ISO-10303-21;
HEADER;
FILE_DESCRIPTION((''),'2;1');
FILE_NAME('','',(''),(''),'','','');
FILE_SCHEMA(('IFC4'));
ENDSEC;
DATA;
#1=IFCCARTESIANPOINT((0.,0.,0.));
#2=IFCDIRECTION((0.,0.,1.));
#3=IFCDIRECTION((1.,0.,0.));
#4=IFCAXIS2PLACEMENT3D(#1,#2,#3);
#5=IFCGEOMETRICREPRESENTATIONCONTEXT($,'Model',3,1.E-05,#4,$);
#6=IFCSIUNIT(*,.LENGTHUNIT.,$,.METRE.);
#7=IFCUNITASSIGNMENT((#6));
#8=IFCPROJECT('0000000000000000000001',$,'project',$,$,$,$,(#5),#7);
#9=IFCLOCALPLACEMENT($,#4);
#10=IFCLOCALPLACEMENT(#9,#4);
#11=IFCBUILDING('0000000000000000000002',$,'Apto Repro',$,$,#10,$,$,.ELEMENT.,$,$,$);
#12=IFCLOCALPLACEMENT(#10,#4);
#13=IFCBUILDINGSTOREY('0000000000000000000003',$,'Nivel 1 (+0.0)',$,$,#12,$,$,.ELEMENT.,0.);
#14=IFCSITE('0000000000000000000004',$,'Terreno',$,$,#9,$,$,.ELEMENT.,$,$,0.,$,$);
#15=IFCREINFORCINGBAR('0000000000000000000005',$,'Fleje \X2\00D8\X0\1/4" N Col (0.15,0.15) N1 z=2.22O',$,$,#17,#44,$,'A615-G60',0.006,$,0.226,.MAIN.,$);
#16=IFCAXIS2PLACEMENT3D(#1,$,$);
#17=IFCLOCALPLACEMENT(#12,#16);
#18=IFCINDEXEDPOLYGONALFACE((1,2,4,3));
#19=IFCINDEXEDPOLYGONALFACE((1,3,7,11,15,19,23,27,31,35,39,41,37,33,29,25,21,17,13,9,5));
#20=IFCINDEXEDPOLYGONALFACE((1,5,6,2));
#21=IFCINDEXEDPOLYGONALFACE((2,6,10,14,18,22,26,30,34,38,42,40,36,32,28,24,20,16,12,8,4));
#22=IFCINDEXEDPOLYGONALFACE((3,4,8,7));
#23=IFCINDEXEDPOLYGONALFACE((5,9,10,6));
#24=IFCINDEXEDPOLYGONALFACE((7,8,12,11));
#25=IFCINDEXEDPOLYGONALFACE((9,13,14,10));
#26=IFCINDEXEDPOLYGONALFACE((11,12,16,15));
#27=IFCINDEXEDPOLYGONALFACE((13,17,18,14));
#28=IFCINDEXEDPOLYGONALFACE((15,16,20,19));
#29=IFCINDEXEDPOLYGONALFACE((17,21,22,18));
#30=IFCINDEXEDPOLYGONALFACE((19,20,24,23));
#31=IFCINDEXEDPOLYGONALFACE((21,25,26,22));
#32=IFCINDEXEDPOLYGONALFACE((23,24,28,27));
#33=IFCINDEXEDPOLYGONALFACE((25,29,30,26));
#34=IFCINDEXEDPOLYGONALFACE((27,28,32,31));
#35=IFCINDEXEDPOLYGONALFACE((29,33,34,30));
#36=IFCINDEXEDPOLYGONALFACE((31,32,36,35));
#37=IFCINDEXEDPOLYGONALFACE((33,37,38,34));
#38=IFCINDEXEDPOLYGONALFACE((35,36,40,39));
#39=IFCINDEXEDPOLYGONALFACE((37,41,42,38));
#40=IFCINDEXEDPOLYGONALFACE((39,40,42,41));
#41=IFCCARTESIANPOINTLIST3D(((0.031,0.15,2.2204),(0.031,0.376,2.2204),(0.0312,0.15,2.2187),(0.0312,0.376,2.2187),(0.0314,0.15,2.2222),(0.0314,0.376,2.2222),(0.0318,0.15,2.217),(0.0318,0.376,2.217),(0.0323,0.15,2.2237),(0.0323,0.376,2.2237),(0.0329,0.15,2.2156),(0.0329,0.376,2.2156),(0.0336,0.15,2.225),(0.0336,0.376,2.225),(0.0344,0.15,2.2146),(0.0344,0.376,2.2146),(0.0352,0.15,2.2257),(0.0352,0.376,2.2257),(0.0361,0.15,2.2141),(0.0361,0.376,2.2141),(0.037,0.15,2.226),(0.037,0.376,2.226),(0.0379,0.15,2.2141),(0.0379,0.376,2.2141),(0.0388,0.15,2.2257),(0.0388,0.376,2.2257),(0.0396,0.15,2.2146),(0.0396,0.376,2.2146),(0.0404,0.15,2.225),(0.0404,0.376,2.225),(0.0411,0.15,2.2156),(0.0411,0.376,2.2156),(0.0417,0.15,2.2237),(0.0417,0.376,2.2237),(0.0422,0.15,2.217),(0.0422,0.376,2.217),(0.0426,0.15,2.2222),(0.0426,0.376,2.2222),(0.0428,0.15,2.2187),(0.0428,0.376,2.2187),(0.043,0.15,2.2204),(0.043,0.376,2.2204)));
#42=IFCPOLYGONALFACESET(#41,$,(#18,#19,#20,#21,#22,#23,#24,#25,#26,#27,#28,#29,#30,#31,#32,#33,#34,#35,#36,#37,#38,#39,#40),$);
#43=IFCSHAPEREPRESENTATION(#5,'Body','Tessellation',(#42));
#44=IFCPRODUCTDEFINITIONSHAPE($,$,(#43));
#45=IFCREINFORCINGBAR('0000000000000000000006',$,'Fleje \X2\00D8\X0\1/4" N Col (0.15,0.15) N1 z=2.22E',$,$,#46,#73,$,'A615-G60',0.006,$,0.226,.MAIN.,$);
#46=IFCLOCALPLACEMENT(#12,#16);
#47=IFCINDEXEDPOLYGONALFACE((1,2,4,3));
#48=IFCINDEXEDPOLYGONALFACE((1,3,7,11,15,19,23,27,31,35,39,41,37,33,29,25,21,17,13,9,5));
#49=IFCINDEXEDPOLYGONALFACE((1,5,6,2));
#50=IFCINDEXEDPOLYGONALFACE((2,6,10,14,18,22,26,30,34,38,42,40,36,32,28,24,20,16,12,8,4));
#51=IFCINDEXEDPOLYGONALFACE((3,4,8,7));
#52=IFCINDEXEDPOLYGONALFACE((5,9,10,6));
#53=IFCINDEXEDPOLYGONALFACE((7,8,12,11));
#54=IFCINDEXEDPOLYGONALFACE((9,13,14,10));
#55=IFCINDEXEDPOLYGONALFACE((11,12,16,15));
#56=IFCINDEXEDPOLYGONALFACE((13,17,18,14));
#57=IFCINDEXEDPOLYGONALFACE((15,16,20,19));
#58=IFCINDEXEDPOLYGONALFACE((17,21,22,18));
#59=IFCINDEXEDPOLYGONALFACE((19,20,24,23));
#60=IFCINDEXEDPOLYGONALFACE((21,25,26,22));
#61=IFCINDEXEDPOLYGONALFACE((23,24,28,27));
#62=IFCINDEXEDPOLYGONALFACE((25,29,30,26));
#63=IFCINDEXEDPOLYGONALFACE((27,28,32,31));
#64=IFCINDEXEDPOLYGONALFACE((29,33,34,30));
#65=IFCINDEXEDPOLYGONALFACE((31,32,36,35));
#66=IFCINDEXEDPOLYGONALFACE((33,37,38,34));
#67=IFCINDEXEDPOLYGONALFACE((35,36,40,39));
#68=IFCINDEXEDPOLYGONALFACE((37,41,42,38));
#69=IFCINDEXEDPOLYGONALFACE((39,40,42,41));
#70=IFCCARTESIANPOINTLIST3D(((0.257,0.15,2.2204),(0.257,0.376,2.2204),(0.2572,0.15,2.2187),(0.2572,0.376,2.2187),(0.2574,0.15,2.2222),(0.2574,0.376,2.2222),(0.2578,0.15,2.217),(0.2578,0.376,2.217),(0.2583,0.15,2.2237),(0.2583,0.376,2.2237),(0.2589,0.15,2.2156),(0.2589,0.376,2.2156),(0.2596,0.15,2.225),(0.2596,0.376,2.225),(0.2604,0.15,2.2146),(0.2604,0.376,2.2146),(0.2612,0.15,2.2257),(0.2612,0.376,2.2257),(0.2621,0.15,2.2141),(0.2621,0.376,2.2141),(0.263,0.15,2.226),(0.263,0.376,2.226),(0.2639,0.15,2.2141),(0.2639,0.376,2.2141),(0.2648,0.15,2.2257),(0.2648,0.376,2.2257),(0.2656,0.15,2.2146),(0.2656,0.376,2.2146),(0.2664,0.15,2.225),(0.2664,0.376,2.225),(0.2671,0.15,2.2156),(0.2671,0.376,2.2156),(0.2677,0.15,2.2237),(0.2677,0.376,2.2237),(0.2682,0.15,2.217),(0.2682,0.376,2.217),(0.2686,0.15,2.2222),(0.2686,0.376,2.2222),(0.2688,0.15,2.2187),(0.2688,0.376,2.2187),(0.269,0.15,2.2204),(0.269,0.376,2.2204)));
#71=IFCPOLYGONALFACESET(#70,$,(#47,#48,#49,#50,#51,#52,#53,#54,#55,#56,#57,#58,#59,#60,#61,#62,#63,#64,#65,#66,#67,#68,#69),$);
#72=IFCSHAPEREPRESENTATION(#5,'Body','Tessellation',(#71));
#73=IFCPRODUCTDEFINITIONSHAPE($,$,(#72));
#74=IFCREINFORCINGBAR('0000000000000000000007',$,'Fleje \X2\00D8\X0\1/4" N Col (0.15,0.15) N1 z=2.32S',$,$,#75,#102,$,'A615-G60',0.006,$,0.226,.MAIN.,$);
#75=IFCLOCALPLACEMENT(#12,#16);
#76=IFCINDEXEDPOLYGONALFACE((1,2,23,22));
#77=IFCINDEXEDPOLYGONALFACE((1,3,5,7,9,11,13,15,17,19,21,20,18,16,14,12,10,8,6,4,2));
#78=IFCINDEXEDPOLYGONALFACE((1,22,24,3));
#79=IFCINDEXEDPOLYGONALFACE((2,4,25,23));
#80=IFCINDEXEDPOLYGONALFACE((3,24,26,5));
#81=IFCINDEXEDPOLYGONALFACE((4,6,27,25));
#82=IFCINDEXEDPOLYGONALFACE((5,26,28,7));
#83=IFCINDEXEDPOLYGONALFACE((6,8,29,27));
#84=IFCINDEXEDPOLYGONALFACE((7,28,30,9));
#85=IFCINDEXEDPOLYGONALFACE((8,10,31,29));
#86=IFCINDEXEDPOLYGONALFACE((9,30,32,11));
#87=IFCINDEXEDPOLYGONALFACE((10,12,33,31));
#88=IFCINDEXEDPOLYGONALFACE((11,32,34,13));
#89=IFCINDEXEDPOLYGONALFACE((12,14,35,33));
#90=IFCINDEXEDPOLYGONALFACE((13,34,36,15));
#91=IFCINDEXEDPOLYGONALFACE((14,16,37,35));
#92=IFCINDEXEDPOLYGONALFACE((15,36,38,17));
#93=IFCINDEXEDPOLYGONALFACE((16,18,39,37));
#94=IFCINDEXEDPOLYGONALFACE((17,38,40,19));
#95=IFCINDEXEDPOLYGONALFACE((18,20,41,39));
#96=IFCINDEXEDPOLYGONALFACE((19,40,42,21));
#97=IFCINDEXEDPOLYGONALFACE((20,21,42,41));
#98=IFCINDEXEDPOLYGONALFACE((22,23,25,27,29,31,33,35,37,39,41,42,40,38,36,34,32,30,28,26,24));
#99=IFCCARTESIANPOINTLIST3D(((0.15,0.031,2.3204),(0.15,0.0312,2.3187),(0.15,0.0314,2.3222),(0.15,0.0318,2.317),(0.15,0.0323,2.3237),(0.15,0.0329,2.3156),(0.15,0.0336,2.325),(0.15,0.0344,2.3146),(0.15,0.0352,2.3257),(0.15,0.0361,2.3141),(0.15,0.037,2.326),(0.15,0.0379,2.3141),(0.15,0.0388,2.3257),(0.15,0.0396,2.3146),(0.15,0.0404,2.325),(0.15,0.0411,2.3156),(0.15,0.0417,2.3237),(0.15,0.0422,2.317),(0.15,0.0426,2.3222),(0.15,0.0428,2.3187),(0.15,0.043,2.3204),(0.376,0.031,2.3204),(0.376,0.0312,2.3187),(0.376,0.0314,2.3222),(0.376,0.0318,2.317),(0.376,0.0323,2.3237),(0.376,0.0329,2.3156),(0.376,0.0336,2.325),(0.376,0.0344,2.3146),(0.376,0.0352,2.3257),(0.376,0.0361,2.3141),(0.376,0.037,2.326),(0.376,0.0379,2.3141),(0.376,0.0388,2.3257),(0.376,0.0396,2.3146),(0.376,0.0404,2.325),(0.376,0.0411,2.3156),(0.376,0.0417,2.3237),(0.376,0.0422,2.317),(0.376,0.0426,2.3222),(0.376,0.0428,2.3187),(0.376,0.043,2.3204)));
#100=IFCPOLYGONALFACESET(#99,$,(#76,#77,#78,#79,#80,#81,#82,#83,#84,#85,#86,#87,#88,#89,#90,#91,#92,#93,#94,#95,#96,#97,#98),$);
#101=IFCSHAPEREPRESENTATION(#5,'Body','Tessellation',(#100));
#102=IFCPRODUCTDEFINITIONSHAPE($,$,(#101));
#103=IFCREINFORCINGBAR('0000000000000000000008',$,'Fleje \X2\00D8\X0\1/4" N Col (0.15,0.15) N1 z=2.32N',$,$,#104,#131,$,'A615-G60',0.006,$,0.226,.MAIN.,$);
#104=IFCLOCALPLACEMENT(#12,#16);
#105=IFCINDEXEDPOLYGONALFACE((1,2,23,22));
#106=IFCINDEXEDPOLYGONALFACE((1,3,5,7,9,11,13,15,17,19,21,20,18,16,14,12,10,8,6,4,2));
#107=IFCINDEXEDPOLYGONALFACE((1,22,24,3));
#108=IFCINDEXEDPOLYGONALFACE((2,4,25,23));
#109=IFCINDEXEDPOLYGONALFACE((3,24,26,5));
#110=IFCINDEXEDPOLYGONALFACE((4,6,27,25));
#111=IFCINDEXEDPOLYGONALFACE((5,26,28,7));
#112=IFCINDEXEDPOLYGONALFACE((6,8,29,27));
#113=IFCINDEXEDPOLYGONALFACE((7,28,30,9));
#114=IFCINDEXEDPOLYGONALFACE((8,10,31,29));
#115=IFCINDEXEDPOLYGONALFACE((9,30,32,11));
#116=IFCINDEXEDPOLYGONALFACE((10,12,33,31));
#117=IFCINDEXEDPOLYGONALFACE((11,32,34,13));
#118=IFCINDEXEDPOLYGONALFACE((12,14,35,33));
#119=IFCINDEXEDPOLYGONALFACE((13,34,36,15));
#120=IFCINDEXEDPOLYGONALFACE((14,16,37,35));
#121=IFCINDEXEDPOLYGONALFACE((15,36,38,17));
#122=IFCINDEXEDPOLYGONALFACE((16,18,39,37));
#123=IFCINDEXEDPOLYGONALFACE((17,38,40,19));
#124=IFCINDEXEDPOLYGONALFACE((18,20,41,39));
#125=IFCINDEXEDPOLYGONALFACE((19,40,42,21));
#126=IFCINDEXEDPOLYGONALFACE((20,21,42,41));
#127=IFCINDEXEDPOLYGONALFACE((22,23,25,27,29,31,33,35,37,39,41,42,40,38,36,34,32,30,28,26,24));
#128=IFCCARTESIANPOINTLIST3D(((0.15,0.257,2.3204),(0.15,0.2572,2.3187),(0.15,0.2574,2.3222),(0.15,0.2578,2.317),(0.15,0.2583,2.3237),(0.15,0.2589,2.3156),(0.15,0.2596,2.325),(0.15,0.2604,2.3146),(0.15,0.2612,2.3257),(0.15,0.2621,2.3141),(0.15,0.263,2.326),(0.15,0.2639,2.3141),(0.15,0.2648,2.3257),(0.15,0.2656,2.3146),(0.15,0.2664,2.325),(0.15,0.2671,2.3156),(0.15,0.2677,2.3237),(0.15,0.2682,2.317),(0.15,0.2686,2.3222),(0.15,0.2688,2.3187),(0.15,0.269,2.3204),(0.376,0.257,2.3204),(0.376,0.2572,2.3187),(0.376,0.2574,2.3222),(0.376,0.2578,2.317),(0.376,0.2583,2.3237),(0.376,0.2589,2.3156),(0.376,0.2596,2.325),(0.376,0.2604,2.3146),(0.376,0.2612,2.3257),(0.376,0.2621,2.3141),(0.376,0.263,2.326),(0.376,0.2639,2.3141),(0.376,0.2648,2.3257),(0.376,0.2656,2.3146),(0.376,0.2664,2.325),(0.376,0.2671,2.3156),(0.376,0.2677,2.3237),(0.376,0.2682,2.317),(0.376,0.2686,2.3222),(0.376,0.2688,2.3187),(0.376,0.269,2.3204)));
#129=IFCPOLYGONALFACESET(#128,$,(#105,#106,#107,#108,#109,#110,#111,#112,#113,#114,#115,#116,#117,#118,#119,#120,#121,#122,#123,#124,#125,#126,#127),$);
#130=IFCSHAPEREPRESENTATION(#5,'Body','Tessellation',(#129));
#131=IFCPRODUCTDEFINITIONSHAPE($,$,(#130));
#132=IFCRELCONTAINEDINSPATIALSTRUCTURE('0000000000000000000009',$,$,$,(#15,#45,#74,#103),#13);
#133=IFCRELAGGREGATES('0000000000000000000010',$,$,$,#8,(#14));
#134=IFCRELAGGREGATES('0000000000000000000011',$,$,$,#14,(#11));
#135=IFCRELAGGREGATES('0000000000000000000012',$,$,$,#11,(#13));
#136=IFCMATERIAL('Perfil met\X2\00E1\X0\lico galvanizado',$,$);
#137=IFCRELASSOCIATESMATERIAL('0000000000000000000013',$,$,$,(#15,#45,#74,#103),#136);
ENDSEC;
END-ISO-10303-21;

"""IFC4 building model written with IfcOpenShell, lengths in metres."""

from ifc_helpers import new_model, si_unit, frame, origin_with_axes, origin_2d_with_axis, place, context, project, spatial, circle, extrude, material, element, save


model = new_model("IFC4")

# Units and contexts
model_context = context("Model", 3, precision=1e-05, world=origin_with_axes())
ifc_project = project(units=[si_unit("LENGTHUNIT", "METRE")], contexts=[model_context])

# Site, building, storey
site_placement = place(None, origin_with_axes())
site = spatial("IfcSite", under=ifc_project, at=site_placement, Name="Terreno", CompositionType="ELEMENT", RefElevation=0.0)
building_placement = place(site_placement, origin_with_axes())
building = spatial("IfcBuilding", under=site, at=building_placement, Name="Apto Repro", CompositionType="ELEMENT")
storey_placement = place(building_placement, origin_with_axes())
storey = spatial("IfcBuildingStorey", under=building, at=storey_placement, Name="Nivel 1 (+0.0)", CompositionType="ELEMENT", Elevation=0.0)

# Reinforcing bars
ifc_material = material(Name="Perfil metálico galvanizado")
reinforcing_bar_1_placement = place(storey_placement, origin_with_axes())
element("IfcReinforcingBar", 1, at=reinforcing_bar_1_placement, inside=storey, material=ifc_material, Name="Fleje Ø1/4\" N Col (0.15,0.15) N1 z=2.22O", SteelGrade="A615-G60", BarLength=0.226, NominalDiameter=0.006, PredefinedType="MAIN", context=model_context, shape_type="SweptSolid", body=[
    extrude(circle(Radius=0.006, at=origin_2d_with_axis()), frame((0.037, 0.15, 2.22), z_axis=(0.0, 1.0, 0.0), x_axis=(0.0, 0.0, 1.0)), (0.0, 0.0, 1.0), 0.226),
])
reinforcing_bar_2_placement = place(storey_placement, origin_with_axes())
element("IfcReinforcingBar", 2, at=reinforcing_bar_2_placement, inside=storey, material=ifc_material, Name="Fleje Ø1/4\" N Col (0.15,0.15) N1 z=2.22E", SteelGrade="A615-G60", BarLength=0.226, NominalDiameter=0.006, PredefinedType="MAIN", context=model_context, shape_type="SweptSolid", body=[
    extrude(circle(Radius=0.006, at=origin_2d_with_axis()), frame((0.263, 0.15, 2.22), z_axis=(0.0, 1.0, 0.0), x_axis=(0.0, 0.0, 1.0)), (0.0, 0.0, 1.0), 0.226),
])
reinforcing_bar_3_placement = place(storey_placement, origin_with_axes())
element("IfcReinforcingBar", 3, at=reinforcing_bar_3_placement, inside=storey, material=ifc_material, Name="Fleje Ø1/4\" N Col (0.15,0.15) N1 z=2.32S", SteelGrade="A615-G60", BarLength=0.226, NominalDiameter=0.006, PredefinedType="MAIN", context=model_context, shape_type="SweptSolid", body=[
    extrude(circle(Radius=0.006, at=origin_2d_with_axis()), frame((0.15, 0.037, 2.32), z_axis=(1.0, 0.0, 0.0), x_axis=(0.0, 0.0, 1.0)), (0.0, 0.0, 1.0), 0.226),
])
reinforcing_bar_4_placement = place(storey_placement, origin_with_axes())
element("IfcReinforcingBar", 4, at=reinforcing_bar_4_placement, inside=storey, material=ifc_material, Name="Fleje Ø1/4\" N Col (0.15,0.15) N1 z=2.32N", SteelGrade="A615-G60", BarLength=0.226, NominalDiameter=0.006, PredefinedType="MAIN", context=model_context, shape_type="SweptSolid", body=[
    extrude(circle(Radius=0.006, at=origin_2d_with_axis()), frame((0.15, 0.263, 2.32), z_axis=(1.0, 0.0, 0.0), x_axis=(0.0, 0.0, 1.0)), (0.0, 0.0, 1.0), 0.226),
])

save(model, "model.ifc")
